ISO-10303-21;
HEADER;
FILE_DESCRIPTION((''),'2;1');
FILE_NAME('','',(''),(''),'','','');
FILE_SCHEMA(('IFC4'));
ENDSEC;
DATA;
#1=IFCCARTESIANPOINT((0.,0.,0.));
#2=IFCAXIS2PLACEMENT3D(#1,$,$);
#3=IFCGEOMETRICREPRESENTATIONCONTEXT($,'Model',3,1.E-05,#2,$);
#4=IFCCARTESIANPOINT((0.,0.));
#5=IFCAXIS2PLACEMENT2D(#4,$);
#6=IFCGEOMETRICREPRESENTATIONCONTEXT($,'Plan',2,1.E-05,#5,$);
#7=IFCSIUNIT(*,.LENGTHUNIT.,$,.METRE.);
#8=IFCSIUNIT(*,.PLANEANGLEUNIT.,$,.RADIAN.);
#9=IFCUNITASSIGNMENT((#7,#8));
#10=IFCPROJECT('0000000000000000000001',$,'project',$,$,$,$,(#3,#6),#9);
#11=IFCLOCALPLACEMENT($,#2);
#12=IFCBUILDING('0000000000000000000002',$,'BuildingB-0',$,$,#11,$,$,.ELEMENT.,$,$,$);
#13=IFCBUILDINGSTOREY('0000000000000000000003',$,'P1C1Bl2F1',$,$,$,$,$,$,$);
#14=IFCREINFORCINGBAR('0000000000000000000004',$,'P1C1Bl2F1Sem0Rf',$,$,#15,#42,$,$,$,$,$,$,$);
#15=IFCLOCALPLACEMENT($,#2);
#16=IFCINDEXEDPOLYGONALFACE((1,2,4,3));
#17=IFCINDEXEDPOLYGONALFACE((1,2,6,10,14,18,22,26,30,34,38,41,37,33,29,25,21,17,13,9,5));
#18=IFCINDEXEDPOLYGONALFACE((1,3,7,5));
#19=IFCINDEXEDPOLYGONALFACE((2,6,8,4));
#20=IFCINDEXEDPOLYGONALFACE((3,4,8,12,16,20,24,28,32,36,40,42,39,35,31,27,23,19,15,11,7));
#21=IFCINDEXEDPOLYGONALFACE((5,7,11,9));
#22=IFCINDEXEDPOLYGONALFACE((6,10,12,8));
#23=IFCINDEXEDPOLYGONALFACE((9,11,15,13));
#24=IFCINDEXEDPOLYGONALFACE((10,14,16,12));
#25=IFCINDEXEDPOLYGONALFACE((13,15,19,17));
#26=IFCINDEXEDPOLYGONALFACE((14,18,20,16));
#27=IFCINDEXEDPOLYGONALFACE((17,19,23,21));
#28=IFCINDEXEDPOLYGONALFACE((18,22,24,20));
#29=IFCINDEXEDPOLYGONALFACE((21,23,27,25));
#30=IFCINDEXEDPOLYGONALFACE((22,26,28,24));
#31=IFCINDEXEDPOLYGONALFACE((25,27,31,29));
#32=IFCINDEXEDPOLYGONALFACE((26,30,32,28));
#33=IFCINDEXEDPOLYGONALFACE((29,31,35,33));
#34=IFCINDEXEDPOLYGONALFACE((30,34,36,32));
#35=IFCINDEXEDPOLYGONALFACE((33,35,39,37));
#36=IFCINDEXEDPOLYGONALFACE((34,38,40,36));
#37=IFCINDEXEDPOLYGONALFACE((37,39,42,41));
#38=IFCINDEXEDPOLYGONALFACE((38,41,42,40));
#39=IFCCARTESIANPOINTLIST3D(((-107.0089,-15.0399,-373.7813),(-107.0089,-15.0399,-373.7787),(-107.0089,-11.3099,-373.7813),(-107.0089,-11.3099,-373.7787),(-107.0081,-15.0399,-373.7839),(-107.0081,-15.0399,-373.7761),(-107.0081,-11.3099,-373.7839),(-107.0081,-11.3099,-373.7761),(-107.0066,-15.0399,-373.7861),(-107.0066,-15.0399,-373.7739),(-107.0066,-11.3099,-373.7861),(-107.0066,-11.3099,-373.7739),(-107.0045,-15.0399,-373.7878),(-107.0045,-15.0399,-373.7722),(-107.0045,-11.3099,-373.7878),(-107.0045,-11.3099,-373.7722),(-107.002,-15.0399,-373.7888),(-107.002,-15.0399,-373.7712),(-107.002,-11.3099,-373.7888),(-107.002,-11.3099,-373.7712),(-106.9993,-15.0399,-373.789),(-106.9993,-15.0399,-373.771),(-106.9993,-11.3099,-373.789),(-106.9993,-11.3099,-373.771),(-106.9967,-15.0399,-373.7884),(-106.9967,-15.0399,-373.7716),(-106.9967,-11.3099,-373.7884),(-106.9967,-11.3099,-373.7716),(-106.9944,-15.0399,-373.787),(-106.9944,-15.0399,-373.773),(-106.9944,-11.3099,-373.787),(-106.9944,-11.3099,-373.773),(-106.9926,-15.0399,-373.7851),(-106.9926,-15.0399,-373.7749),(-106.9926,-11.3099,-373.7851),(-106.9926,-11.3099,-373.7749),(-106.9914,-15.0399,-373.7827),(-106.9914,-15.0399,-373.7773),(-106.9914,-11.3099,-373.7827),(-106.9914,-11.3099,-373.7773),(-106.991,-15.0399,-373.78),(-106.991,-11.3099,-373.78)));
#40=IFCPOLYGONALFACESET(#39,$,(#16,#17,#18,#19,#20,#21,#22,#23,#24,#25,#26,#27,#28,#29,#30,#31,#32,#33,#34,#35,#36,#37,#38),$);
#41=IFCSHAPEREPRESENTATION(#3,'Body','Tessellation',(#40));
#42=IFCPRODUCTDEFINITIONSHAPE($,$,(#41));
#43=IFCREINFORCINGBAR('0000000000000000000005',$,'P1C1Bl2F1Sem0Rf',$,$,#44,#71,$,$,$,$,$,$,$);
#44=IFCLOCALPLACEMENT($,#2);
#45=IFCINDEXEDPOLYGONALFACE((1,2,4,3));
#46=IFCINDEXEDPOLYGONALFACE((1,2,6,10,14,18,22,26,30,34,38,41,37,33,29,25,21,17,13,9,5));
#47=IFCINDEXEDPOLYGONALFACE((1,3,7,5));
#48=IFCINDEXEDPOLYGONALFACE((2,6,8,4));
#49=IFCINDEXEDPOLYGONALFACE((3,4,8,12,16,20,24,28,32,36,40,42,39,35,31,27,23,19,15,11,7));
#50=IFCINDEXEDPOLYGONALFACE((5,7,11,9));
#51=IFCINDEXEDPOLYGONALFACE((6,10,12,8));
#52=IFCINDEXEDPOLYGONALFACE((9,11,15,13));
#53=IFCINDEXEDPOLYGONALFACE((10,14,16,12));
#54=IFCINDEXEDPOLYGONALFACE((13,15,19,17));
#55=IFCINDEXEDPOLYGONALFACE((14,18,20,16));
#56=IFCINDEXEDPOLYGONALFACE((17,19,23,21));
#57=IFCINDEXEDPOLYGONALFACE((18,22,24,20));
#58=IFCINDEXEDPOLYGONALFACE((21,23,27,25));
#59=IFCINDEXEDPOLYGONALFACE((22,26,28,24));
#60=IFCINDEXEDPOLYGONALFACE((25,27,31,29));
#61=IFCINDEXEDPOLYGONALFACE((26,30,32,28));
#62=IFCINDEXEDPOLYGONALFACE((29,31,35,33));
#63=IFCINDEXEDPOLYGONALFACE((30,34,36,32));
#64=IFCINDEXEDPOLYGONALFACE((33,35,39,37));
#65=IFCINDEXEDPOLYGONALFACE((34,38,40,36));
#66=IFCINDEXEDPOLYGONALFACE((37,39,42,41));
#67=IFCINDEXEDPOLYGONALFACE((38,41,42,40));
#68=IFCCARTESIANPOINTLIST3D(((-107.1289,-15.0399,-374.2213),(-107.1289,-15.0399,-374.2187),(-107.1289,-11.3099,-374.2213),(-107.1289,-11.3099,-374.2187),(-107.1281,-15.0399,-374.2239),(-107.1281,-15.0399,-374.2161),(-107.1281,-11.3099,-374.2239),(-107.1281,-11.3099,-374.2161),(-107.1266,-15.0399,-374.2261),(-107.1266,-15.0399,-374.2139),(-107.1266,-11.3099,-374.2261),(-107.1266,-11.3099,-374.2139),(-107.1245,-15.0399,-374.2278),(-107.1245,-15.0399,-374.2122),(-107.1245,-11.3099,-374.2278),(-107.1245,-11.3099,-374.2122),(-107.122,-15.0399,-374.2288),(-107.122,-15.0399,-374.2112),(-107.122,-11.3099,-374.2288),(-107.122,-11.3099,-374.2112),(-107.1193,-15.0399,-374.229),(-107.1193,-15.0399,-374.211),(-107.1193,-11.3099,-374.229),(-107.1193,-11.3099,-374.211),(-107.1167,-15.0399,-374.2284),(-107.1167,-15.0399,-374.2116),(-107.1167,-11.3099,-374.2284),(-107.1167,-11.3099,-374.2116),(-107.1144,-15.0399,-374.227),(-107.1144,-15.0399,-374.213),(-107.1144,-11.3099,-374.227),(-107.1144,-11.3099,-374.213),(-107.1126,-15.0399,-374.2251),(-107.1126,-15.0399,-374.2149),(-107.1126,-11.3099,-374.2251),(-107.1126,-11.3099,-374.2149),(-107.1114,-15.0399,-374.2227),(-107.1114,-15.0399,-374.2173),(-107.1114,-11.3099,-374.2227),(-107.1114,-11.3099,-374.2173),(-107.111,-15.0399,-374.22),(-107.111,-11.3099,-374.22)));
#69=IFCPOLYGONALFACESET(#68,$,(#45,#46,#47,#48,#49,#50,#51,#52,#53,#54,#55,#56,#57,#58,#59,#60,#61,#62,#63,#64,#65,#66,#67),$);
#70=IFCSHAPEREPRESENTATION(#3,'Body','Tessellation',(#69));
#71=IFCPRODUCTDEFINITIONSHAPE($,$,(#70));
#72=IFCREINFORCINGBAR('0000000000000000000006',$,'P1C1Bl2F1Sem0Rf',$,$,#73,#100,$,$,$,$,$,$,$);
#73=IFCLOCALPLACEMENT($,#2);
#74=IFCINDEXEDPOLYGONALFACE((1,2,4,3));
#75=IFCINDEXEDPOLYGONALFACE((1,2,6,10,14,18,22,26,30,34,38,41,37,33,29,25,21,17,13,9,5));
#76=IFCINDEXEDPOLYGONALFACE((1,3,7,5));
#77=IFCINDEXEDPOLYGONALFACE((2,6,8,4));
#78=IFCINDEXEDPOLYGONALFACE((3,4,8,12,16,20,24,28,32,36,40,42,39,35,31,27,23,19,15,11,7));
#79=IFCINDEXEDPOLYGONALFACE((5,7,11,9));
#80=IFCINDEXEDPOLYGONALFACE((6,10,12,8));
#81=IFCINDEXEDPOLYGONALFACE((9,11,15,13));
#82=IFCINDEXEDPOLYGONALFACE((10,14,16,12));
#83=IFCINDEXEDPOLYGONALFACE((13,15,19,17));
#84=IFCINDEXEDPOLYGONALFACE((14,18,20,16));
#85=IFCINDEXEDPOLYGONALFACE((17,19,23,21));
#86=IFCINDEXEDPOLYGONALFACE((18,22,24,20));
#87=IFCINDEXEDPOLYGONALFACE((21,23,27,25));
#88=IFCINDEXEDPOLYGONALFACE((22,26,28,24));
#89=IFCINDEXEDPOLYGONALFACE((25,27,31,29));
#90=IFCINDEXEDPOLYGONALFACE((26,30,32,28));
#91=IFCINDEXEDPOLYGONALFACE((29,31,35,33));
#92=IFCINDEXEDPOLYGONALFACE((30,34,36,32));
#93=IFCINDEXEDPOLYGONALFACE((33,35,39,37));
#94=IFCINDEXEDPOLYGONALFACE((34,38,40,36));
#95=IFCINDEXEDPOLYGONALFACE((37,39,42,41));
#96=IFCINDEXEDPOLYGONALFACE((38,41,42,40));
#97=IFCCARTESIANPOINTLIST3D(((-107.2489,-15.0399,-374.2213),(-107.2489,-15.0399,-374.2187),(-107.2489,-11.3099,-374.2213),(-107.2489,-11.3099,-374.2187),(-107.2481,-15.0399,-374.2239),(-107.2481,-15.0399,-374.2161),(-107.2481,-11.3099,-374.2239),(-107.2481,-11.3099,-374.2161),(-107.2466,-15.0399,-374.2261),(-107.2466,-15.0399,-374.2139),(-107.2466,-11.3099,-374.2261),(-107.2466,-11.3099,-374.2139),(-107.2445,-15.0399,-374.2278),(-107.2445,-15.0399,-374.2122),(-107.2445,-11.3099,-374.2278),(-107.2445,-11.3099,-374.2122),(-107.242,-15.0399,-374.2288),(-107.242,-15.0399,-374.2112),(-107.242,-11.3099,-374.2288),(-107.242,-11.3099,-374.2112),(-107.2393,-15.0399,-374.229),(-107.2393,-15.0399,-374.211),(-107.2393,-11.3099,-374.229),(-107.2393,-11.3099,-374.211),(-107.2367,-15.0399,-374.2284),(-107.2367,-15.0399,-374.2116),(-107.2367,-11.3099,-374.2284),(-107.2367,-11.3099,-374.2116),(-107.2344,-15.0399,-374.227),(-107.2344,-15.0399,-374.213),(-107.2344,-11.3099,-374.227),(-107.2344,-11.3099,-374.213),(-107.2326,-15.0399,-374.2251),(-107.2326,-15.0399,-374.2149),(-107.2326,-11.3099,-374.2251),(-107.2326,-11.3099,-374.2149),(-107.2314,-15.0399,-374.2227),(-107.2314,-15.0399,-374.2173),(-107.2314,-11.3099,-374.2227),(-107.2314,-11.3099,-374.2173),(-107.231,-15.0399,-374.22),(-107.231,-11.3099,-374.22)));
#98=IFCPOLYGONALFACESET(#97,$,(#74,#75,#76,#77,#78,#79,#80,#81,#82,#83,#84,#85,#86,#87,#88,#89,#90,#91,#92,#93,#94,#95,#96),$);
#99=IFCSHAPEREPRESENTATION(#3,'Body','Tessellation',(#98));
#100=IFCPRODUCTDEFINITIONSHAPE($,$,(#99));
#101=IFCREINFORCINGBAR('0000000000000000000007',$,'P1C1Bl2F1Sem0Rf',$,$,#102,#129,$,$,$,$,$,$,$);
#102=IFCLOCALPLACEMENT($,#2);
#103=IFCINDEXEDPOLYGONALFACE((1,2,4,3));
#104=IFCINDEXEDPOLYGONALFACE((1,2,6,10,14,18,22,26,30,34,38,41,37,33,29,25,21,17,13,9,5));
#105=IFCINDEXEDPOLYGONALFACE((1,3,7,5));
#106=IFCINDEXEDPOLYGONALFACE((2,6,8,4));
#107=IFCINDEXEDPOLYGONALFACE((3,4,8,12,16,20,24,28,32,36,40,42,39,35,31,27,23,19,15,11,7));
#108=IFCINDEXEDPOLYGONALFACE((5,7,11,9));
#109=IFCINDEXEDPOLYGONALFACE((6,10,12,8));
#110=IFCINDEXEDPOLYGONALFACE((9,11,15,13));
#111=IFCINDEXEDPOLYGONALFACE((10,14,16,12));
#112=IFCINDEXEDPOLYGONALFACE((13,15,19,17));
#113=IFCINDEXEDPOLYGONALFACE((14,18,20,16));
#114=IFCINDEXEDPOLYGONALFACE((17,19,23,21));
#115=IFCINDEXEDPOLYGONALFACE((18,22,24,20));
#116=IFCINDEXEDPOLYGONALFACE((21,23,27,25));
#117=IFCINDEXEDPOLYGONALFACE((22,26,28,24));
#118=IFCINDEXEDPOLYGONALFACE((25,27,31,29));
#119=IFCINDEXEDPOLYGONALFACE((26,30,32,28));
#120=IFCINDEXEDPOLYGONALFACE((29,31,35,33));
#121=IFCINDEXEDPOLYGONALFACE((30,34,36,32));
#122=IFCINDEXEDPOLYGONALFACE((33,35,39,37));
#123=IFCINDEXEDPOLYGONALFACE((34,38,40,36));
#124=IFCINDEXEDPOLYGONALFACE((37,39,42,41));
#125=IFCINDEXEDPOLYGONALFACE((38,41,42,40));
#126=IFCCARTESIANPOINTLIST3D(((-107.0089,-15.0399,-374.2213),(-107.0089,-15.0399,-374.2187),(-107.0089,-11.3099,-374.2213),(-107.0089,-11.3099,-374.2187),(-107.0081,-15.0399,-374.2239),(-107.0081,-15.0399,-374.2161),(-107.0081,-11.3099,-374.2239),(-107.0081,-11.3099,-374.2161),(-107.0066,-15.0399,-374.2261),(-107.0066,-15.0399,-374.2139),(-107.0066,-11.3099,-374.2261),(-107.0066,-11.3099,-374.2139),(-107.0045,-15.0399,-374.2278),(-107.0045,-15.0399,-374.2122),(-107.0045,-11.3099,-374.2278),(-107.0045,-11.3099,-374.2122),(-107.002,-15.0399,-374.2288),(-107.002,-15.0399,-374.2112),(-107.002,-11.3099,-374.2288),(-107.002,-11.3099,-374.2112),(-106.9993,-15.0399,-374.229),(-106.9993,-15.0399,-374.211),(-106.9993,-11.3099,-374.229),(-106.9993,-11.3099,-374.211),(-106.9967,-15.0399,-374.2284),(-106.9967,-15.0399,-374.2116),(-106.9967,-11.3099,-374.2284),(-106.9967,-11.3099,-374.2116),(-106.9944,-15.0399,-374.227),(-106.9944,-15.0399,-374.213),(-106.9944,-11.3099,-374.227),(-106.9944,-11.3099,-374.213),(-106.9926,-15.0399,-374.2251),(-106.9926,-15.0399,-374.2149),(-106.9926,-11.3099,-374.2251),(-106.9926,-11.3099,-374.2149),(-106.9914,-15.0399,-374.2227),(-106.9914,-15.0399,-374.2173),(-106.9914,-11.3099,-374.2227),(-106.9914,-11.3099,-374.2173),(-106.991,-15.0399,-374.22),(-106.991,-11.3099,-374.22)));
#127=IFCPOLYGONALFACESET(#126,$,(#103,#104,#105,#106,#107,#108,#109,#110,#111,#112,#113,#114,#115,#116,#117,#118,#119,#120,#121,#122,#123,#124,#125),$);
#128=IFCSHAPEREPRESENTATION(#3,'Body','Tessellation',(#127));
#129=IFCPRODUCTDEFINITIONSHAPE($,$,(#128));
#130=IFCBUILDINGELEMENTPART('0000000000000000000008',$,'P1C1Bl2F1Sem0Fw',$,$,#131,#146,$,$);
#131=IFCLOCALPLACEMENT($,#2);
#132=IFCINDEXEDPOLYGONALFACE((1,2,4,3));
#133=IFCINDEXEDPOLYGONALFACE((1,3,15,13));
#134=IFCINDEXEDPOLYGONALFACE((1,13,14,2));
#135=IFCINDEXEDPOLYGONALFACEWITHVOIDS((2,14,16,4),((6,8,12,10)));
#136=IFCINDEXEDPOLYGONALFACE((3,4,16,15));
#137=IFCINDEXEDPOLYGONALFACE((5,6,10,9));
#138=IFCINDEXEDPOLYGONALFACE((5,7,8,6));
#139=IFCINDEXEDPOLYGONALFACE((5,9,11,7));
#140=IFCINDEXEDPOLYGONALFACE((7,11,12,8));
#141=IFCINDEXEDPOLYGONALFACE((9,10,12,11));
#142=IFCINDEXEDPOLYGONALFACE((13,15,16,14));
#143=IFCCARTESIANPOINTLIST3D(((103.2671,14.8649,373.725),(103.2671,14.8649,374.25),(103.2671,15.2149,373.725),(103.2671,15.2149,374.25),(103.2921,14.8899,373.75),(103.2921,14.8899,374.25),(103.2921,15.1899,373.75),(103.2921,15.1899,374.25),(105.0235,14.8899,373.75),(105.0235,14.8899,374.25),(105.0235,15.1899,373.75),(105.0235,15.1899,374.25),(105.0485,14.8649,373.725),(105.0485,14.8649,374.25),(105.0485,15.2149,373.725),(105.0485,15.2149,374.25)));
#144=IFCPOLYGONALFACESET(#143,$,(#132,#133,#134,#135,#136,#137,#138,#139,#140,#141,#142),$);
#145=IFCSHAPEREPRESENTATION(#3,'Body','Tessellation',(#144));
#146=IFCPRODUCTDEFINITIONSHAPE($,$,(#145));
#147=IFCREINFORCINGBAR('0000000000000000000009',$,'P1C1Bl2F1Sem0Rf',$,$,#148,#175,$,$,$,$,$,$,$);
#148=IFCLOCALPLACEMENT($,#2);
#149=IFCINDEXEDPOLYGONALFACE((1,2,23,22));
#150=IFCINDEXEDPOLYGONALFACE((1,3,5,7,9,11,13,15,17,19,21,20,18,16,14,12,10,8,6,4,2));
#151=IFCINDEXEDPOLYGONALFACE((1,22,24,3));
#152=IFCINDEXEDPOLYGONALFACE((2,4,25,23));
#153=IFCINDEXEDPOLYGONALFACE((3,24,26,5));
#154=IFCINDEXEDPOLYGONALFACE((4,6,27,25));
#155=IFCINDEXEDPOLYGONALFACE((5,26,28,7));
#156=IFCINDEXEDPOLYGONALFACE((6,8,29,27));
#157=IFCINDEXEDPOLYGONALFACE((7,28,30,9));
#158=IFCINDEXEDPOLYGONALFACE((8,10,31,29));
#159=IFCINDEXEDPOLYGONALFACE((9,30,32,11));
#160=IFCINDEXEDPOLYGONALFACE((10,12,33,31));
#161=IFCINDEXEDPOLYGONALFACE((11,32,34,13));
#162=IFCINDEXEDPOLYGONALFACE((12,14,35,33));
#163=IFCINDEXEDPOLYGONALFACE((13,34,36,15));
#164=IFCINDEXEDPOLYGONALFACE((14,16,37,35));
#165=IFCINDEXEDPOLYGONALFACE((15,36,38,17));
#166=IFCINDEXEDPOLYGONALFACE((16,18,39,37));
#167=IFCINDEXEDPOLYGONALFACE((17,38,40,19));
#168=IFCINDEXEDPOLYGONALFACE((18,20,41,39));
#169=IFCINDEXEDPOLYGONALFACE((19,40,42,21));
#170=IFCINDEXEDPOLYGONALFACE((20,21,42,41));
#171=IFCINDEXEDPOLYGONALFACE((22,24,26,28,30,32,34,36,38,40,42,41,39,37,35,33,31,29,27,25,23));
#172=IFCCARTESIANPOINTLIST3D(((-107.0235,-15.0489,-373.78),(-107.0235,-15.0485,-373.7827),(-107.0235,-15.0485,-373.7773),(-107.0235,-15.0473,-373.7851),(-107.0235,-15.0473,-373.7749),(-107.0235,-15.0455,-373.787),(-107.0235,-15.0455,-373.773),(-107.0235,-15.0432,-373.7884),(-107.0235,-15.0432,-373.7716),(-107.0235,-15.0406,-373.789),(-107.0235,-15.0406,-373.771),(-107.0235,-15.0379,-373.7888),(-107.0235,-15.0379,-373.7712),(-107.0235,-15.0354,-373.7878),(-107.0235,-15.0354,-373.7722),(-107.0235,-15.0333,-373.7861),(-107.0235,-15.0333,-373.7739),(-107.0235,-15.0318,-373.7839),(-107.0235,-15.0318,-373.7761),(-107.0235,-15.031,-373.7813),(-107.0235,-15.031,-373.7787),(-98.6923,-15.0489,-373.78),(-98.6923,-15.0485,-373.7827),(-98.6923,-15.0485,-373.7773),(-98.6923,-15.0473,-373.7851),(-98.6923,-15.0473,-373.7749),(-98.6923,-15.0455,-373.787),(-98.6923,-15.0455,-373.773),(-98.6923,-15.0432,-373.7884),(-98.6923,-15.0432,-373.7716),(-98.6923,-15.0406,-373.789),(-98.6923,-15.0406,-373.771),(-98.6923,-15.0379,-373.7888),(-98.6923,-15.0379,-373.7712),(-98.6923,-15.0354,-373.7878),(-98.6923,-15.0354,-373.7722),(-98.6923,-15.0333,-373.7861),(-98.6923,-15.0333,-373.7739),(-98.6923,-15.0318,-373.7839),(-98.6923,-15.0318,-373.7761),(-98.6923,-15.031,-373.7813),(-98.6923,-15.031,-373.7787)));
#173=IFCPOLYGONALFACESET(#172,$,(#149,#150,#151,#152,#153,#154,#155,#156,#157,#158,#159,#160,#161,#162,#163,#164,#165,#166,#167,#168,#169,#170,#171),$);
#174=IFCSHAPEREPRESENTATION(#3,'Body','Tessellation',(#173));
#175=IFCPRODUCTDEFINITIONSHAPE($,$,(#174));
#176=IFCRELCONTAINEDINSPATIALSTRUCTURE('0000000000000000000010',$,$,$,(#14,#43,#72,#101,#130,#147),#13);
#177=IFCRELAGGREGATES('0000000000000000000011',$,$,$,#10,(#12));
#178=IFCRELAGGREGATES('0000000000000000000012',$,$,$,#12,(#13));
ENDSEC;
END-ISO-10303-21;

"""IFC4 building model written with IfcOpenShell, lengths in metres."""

from ifc_helpers import new_model, entity, si_unit, origin, origin_2d, place, context, project, spatial, polyline, outline, extrude, element, save


model = new_model("IFC4")

# Units and contexts
model_context = context("Model", 3, precision=1e-05, world=origin())
plan_context = context("Plan", 2, precision=1e-05, world=origin_2d())
ifc_project = project(units=[si_unit("LENGTHUNIT", "METRE"), si_unit("PLANEANGLEUNIT", "RADIAN")], contexts=[model_context, plan_context])

# Building, storey
building_placement = place(None, origin())
building = spatial("IfcBuilding", under=ifc_project, at=building_placement, Name="BuildingB-0", CompositionType="ELEMENT")
storey = spatial("IfcBuildingStorey", under=building, Name="P1C1Bl2F1")

# Reinforcing bars
element("IfcReinforcingBar", 1, inside=storey, Name="P1C1Bl2F1Sem0Rf", context=model_context, shape_type="SweptSolid", body=[
    entity("IfcSurfaceCurveSweptAreaSolid", entity("IfcCircleProfileDef", "AREA", None, None, 0.009), None, entity("IfcPolyline", [entity("IfcCartesianPoint", [107.0, 11.3099, 373.78]), entity("IfcCartesianPoint", [107.0, 15.0399, 373.78])]), None, None, entity("IfcPlane", entity("IfcAxis2Placement3D", entity("IfcCartesianPoint", [107.0, 11.3099, 373.78]), entity("IfcDirection", [0.0, 0.0, 1.0]), entity("IfcDirection", [1.0, 0.0, 0.0])))),
])
element("IfcReinforcingBar", 2, inside=storey, Name="P1C1Bl2F1Sem0Rf", context=model_context, shape_type="SweptSolid", body=[
    entity("IfcSurfaceCurveSweptAreaSolid", entity("IfcCircleProfileDef", "AREA", None, None, 0.009), None, entity("IfcPolyline", [entity("IfcCartesianPoint", [107.12, 11.3099, 374.22]), entity("IfcCartesianPoint", [107.12, 15.0399, 374.22])]), None, None, entity("IfcPlane", entity("IfcAxis2Placement3D", entity("IfcCartesianPoint", [107.12, 11.3099, 374.22]), entity("IfcDirection", [0.0, 0.0, 1.0]), entity("IfcDirection", [1.0, 0.0, 0.0])))),
])
element("IfcReinforcingBar", 3, inside=storey, Name="P1C1Bl2F1Sem0Rf", context=model_context, shape_type="SweptSolid", body=[
    entity("IfcSurfaceCurveSweptAreaSolid", entity("IfcCircleProfileDef", "AREA", None, None, 0.009), None, entity("IfcPolyline", [entity("IfcCartesianPoint", [107.24, 11.3099, 374.22]), entity("IfcCartesianPoint", [107.24, 15.0399, 374.22])]), None, None, entity("IfcPlane", entity("IfcAxis2Placement3D", entity("IfcCartesianPoint", [107.24, 11.3099, 374.22]), entity("IfcDirection", [0.0, 0.0, 1.0]), entity("IfcDirection", [1.0, 0.0, 0.0])))),
])
element("IfcReinforcingBar", 4, inside=storey, Name="P1C1Bl2F1Sem0Rf", context=model_context, shape_type="SweptSolid", body=[
    entity("IfcSurfaceCurveSweptAreaSolid", entity("IfcCircleProfileDef", "AREA", None, None, 0.009), None, entity("IfcPolyline", [entity("IfcCartesianPoint", [107.0, 11.3099, 374.22]), entity("IfcCartesianPoint", [107.0, 15.0399, 374.22])]), None, None, entity("IfcPlane", entity("IfcAxis2Placement3D", entity("IfcCartesianPoint", [107.0, 11.3099, 374.22]), entity("IfcDirection", [0.0, 0.0, 1.0]), entity("IfcDirection", [1.0, 0.0, 0.0])))),
])

# Building element part, opening
building_element_part_1 = element("IfcBuildingElementPart", 5, inside=storey, Name="P1C1Bl2F1Sem0Fw", context=model_context, shape_type="SweptSolid", body=[
    extrude(outline(polyline([(105.0485, 14.8649, 373.725), (105.0485, 15.2149, 373.725), (103.2671, 15.2149, 373.725), (103.2671, 14.8649, 373.725), (105.0485, 14.8649, 373.725)])), None, (0.0, 0.0, 1.0), 0.525),
])
element("IfcOpeningElement", 6, inside=storey, cuts=building_element_part_1, context=model_context, shape_type="SweptSolid", body=[
    extrude(outline(polyline([(105.0235, 14.8899, 373.75), (105.0235, 15.1899, 373.75), (103.2921, 15.1899, 373.75), (103.2921, 14.8899, 373.75), (105.0235, 14.8899, 373.75)])), None, (0.0, 0.0, 1.0), 0.5),
])

# Reinforcing bar
element("IfcReinforcingBar", 7, inside=storey, Name="P1C1Bl2F1Sem0Rf", context=model_context, shape_type="SweptSolid", body=[
    entity("IfcSurfaceCurveSweptAreaSolid", entity("IfcCircleProfileDef", "AREA", None, None, 0.009), None, entity("IfcPolyline", [entity("IfcCartesianPoint", [107.0235, 15.0399, 373.78]), entity("IfcCartesianPoint", [98.6923, 15.0399, 373.78])]), None, None, entity("IfcPlane", entity("IfcAxis2Placement3D", entity("IfcCartesianPoint", [107.0235, 15.0399, 373.78]), entity("IfcDirection", [0.0, 0.0, 1.0]), entity("IfcDirection", [1.0, 0.0, 0.0])))),
])

save(model, "model.ifc")
